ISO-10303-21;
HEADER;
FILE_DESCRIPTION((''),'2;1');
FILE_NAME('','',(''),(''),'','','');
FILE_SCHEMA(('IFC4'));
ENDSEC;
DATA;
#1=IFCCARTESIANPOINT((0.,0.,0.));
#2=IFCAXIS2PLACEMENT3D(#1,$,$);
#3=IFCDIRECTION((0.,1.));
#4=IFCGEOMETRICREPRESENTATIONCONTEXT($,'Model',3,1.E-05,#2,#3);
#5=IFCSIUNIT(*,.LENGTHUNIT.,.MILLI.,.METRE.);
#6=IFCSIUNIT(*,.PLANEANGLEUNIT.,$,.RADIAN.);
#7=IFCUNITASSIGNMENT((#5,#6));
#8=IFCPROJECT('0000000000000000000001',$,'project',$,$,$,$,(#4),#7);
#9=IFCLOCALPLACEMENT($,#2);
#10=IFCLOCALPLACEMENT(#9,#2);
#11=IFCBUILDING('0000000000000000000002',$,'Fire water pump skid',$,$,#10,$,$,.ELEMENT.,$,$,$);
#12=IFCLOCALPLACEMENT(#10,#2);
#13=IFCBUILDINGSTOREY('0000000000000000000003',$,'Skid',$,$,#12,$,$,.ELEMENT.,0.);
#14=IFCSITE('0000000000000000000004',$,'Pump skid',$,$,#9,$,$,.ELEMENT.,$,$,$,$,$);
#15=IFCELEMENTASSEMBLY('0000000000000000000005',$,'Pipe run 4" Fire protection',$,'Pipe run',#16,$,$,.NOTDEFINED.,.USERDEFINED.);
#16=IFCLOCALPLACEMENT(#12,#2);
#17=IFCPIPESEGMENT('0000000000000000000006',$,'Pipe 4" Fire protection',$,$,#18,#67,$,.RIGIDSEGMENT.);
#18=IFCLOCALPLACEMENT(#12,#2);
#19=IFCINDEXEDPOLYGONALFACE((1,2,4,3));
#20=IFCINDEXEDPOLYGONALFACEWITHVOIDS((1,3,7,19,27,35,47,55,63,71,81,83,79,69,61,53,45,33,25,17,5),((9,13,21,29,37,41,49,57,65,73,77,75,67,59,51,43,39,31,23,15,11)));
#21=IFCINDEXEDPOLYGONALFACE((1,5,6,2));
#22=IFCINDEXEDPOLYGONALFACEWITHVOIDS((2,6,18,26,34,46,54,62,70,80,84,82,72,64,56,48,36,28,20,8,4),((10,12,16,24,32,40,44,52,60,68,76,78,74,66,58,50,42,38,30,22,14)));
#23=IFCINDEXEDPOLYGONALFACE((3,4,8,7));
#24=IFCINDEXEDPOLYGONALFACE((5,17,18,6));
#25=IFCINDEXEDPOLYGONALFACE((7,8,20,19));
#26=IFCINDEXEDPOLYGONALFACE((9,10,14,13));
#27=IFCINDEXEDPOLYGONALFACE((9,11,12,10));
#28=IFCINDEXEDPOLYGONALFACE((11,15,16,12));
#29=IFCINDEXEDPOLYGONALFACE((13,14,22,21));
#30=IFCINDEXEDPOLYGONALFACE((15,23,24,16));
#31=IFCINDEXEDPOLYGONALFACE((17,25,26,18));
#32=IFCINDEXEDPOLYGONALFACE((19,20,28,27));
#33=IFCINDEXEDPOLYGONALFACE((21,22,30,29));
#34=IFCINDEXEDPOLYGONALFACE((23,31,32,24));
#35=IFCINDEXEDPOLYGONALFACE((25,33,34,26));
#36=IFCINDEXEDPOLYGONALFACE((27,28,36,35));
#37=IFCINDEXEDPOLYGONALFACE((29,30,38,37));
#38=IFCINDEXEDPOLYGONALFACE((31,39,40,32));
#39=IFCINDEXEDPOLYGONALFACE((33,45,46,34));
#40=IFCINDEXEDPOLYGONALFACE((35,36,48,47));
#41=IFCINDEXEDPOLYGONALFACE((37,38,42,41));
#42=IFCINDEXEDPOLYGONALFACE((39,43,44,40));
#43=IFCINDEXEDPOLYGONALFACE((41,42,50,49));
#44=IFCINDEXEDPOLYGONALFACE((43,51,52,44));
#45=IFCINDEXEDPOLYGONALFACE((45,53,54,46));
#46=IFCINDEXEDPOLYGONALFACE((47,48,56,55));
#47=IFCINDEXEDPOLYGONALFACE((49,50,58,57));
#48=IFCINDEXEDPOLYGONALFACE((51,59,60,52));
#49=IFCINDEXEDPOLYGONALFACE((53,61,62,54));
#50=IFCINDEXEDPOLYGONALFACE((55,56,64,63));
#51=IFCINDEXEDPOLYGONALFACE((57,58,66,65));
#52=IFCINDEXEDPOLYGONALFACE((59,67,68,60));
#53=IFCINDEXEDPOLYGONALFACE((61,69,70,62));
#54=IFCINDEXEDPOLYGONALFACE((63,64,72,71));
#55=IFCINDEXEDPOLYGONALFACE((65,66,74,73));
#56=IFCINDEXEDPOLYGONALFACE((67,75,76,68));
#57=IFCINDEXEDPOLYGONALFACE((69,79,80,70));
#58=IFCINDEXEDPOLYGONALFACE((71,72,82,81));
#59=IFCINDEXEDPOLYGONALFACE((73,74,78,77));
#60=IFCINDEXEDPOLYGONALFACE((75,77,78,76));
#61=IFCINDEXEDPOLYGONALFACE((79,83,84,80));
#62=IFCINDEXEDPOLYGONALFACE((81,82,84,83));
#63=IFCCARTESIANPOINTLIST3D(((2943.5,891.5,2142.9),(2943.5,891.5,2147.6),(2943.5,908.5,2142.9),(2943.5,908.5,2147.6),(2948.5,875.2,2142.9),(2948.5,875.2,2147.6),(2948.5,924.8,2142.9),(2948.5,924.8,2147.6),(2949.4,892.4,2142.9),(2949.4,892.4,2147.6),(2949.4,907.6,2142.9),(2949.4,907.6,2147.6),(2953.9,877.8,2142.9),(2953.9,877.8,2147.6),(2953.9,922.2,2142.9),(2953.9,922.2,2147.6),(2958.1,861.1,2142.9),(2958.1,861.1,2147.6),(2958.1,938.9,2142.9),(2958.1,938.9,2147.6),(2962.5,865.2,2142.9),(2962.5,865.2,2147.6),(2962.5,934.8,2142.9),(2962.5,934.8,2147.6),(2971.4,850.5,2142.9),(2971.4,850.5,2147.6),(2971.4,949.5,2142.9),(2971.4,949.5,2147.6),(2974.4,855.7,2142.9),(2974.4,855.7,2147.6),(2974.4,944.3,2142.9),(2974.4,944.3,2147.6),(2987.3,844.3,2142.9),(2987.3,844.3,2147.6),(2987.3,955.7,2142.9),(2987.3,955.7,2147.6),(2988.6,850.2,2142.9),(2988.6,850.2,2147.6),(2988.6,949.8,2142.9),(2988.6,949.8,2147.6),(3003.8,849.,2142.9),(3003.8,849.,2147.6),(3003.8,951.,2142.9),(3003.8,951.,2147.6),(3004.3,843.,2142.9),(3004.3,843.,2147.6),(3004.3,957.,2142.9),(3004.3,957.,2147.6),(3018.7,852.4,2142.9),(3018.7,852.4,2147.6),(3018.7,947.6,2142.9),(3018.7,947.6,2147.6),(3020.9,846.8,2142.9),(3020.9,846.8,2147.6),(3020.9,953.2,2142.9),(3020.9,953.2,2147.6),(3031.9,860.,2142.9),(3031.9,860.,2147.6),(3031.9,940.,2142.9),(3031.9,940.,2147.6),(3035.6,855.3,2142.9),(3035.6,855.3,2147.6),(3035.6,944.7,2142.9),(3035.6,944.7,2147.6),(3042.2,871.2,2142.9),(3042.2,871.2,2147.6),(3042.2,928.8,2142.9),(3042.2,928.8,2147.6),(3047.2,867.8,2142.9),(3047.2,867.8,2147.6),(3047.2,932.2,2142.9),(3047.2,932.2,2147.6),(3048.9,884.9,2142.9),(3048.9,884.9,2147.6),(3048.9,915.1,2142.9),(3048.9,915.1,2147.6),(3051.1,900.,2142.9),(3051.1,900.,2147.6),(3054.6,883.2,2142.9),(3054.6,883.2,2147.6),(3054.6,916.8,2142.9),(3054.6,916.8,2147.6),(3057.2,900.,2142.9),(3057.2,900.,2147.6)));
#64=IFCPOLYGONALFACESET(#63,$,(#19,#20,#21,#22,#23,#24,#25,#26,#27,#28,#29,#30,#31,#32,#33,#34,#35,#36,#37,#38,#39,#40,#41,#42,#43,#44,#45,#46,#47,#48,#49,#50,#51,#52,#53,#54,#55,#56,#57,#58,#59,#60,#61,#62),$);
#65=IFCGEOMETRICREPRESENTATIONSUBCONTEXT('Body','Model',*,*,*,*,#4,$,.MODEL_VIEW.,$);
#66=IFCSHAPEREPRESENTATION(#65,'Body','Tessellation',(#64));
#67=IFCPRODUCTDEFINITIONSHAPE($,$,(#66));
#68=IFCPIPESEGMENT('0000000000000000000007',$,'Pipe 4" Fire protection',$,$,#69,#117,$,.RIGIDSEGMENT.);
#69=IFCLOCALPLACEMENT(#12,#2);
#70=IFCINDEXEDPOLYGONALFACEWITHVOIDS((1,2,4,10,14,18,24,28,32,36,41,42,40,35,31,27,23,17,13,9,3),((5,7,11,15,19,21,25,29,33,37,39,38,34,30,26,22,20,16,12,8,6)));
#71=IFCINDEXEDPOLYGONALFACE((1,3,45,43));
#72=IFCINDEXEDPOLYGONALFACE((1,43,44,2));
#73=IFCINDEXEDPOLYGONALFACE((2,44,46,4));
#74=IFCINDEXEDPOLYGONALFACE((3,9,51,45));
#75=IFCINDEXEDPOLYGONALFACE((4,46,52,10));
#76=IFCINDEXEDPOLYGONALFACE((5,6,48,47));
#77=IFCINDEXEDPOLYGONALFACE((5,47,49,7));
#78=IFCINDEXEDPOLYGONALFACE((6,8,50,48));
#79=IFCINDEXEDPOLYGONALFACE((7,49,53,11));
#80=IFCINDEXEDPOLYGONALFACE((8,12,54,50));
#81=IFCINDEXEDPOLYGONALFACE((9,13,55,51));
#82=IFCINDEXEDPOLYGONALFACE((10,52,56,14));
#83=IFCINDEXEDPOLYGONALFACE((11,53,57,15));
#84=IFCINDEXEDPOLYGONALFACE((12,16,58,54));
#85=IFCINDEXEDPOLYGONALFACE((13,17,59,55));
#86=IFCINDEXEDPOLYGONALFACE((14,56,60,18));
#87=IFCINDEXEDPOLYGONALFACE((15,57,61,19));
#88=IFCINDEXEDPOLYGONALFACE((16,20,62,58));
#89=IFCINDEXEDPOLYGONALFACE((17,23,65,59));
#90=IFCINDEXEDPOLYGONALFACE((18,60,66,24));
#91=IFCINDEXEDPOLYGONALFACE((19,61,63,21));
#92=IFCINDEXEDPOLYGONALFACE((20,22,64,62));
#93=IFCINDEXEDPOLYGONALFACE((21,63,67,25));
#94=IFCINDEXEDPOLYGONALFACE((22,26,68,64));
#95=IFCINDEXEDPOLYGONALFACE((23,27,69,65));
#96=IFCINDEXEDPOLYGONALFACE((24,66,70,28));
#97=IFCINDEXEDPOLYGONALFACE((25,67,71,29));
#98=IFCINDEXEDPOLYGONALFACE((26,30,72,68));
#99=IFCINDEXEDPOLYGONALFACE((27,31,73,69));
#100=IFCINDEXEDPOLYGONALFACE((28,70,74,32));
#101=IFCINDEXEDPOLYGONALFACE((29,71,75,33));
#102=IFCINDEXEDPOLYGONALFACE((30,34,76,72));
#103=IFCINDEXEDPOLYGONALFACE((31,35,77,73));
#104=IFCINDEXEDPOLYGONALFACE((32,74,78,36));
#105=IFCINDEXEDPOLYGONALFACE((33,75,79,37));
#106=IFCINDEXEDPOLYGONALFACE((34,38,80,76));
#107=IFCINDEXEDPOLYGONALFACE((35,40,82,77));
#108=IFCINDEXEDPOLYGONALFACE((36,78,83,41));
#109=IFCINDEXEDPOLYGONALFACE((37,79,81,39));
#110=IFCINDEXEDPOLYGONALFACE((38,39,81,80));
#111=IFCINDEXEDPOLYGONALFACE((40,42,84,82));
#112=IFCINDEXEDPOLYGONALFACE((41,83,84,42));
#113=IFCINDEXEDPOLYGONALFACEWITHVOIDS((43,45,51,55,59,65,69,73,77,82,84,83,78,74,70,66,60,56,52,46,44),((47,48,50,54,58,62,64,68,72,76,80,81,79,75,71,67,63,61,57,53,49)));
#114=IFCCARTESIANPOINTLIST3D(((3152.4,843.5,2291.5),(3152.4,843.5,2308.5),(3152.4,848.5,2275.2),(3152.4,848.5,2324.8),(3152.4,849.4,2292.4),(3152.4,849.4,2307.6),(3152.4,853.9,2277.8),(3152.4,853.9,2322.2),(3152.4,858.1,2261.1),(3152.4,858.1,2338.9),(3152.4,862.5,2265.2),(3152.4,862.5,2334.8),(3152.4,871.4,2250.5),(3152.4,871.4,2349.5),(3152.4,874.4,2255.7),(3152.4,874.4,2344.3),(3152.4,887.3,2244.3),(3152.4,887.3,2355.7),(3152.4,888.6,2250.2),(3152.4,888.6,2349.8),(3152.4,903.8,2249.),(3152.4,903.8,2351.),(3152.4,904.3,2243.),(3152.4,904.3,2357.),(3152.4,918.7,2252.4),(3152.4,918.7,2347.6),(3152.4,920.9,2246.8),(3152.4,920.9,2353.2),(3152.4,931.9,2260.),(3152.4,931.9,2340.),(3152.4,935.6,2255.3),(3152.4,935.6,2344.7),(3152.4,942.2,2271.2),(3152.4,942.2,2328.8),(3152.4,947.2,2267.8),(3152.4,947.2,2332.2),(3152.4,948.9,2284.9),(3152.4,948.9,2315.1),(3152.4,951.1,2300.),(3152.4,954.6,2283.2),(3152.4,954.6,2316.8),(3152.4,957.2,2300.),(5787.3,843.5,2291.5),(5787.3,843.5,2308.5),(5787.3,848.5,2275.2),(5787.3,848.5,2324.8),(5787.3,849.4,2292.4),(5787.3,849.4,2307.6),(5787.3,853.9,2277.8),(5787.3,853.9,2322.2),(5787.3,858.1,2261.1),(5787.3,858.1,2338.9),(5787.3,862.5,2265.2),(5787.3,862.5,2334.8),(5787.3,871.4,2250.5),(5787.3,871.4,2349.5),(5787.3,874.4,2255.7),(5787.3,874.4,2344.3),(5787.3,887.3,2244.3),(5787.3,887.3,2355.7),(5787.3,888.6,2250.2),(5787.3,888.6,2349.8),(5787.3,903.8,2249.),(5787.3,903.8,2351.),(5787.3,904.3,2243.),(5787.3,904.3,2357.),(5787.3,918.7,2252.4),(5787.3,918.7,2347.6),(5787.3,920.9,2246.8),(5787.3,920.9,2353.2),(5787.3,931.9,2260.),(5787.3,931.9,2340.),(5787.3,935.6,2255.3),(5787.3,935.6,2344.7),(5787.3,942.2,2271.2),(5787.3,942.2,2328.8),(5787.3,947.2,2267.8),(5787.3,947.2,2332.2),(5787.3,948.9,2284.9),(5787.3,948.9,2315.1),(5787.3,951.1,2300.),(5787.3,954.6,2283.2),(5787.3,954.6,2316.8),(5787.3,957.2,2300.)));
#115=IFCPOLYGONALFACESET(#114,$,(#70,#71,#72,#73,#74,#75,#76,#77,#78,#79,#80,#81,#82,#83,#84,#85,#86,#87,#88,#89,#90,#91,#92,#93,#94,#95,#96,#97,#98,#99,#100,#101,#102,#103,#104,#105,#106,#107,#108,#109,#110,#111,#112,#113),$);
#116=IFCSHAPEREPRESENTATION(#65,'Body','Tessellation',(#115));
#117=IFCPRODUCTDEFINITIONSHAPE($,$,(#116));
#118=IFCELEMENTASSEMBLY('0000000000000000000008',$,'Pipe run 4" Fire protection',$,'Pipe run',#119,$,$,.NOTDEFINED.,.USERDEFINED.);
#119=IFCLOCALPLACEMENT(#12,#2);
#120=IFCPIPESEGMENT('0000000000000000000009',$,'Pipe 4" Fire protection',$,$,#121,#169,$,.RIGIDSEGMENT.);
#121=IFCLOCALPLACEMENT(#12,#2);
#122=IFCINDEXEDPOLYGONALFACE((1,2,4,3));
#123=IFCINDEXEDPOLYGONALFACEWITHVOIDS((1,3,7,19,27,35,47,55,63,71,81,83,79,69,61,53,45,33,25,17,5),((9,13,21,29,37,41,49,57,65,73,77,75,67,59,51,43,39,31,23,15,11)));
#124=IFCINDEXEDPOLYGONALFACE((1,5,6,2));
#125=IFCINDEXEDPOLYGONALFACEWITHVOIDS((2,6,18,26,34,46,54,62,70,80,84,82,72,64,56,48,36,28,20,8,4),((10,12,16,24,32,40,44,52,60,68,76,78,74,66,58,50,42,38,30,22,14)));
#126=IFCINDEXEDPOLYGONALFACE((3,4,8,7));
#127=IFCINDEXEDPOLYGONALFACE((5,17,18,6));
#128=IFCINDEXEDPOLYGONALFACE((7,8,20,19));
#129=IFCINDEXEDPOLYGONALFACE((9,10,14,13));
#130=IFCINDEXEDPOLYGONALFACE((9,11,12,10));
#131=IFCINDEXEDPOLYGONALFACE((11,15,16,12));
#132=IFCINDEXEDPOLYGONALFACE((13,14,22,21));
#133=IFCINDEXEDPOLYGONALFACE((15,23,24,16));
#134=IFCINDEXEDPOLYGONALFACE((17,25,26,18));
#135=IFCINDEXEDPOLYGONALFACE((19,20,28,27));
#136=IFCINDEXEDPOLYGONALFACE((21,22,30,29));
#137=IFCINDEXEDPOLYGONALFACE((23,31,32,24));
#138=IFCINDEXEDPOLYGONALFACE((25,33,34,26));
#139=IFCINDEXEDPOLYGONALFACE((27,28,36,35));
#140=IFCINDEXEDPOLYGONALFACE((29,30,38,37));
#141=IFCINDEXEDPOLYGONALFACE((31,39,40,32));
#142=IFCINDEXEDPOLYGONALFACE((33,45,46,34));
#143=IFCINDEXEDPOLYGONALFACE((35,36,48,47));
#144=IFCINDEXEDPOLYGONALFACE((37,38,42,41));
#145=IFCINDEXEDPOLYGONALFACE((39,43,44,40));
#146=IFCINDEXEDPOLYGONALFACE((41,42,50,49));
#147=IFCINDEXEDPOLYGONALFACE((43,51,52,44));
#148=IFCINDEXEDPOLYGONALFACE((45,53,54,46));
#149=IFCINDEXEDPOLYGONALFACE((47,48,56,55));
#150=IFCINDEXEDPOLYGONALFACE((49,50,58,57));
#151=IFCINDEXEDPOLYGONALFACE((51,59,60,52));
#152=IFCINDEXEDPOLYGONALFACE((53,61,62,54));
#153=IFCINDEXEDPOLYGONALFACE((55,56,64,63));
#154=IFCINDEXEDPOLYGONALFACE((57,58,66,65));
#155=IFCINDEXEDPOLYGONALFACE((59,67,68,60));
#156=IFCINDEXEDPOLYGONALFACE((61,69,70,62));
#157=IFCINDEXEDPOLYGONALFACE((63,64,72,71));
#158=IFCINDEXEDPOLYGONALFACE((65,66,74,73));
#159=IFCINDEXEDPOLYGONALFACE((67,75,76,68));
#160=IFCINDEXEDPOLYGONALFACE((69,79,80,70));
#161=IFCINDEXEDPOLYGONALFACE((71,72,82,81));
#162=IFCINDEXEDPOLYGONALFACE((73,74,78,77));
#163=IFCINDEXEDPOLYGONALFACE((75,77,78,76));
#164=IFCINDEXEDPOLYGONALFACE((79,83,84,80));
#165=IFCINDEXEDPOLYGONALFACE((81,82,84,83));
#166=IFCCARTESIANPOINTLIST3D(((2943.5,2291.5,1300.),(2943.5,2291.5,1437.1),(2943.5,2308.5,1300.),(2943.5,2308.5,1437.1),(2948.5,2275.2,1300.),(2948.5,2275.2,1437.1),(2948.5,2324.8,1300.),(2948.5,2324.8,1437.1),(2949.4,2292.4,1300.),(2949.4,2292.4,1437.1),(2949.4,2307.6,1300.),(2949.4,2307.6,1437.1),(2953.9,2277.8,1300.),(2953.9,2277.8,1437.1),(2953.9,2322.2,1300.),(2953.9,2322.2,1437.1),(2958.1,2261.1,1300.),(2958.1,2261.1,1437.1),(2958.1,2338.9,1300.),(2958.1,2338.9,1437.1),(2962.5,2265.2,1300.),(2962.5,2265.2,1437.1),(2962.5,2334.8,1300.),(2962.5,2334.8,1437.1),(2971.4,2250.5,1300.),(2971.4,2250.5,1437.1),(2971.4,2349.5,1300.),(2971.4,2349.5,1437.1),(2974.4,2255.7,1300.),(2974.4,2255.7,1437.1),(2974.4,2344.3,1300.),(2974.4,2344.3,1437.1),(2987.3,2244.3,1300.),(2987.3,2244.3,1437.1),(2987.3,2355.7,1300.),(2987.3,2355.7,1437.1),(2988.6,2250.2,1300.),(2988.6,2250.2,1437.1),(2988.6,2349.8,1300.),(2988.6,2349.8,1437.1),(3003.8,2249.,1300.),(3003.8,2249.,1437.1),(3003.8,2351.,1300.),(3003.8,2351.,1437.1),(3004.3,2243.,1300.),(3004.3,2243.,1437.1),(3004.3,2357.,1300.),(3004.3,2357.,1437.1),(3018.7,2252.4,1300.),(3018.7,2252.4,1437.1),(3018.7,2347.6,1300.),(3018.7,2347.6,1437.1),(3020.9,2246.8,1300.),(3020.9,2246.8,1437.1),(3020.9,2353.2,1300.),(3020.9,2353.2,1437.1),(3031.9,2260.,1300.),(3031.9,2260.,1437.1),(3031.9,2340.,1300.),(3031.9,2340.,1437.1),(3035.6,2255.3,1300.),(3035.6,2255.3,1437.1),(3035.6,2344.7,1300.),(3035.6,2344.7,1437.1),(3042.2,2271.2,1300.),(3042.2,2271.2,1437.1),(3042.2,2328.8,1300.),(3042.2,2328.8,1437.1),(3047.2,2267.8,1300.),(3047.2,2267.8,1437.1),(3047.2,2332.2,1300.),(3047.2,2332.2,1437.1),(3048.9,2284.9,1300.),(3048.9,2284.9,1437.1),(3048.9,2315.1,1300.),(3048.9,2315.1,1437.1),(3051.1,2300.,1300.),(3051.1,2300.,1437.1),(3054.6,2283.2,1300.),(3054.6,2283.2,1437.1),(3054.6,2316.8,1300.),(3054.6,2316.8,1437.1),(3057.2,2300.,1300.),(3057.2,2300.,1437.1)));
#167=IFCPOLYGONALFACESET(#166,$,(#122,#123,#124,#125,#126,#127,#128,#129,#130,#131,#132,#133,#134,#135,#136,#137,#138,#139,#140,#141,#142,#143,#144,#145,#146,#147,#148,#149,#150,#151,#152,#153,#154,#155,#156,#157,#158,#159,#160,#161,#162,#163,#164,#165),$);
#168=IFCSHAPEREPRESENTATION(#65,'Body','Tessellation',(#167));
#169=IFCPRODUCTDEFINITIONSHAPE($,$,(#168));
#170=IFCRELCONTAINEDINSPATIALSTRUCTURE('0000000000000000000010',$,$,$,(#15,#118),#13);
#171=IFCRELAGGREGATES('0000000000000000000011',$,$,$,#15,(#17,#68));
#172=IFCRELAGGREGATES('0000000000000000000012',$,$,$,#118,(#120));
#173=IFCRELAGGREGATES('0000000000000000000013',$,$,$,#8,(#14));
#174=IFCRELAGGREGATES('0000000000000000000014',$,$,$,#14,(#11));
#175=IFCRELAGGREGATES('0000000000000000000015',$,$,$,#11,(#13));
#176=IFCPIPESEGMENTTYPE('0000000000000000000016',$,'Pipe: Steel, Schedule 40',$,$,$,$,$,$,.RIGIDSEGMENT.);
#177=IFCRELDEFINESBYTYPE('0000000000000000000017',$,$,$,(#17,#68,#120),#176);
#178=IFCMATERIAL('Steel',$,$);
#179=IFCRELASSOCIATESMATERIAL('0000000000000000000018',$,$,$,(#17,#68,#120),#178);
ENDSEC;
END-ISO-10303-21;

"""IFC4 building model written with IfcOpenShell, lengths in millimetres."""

from ifc_helpers import new_model, si_unit, direction, frame, origin, origin_with_axes, origin_2d, place, context, subcontext, project, spatial, hollow_circle, extrude, material, type_object, element, aggregate, save


model = new_model("IFC4")

# Units and contexts
model_context = context("Model", 3, precision=1e-05, world=origin(), true_north=direction((0.0, 1.0)))
body_context = subcontext(model_context, "Body", "Model", "MODEL_VIEW")
ifc_project = project(units=[si_unit("LENGTHUNIT", "METRE", prefix="MILLI"), si_unit("PLANEANGLEUNIT", "RADIAN")], contexts=[model_context])

# Site, building, storey
site_placement = place(None, origin())
site = spatial("IfcSite", under=ifc_project, at=site_placement, Name="Pump skid", CompositionType="ELEMENT")
building_placement = place(site_placement, origin())
building = spatial("IfcBuilding", under=site, at=building_placement, Name="Fire water pump skid", CompositionType="ELEMENT")
storey_placement = place(building_placement, origin())
storey = spatial("IfcBuildingStorey", under=building, at=storey_placement, Name="Skid", CompositionType="ELEMENT", Elevation=0.0)

# Element assemblies, pipe segments
ifc_material = material(Name="Steel")
pipe_segment_type = type_object("IfcPipeSegmentType", Name="Pipe: Steel, Schedule 40", PredefinedType="RIGIDSEGMENT")
assembly_1_placement = place(storey_placement, origin_with_axes())
assembly_1 = element("IfcElementAssembly", 1, at=assembly_1_placement, inside=storey, Name="Pipe run 4\" Fire protection", ObjectType="Pipe run", AssemblyPlace="NOTDEFINED", PredefinedType="USERDEFINED")
pipe_segment_1_placement = place(storey_placement, origin_with_axes())
pipe_segment_1 = element("IfcPipeSegment", 2, at=pipe_segment_1_placement, type_object=pipe_segment_type, material=ifc_material, Name="Pipe 4\" Fire protection", PredefinedType="RIGIDSEGMENT", context=body_context, shape_type="SweptSolid", body=[
    extrude(hollow_circle(Radius=57.1, WallThickness=6.0, at=origin_2d()), frame((3000.0, 900.0, 2142.9), z_axis=(0.0, 0.0, 1.0), x_axis=(1.0, 0.0, 0.0)), (0.0, 0.0, 1.0), 4.7),
])
pipe_segment_2_placement = place(storey_placement, origin_with_axes())
pipe_segment_2 = element("IfcPipeSegment", 3, at=pipe_segment_2_placement, type_object=pipe_segment_type, material=ifc_material, Name="Pipe 4\" Fire protection", PredefinedType="RIGIDSEGMENT", context=body_context, shape_type="SweptSolid", body=[
    extrude(hollow_circle(Radius=57.1, WallThickness=6.0, at=origin_2d()), frame((3152.4, 900.0, 2300.0), z_axis=(1.0, 0.0, 0.0), x_axis=(0.0, 1.0, 0.0)), (0.0, 0.0, 1.0), 2634.9),
])
assembly_2_placement = place(storey_placement, origin_with_axes())
assembly_2 = element("IfcElementAssembly", 4, at=assembly_2_placement, inside=storey, Name="Pipe run 4\" Fire protection", ObjectType="Pipe run", AssemblyPlace="NOTDEFINED", PredefinedType="USERDEFINED")
pipe_segment_3_placement = place(storey_placement, origin_with_axes())
pipe_segment_3 = element("IfcPipeSegment", 5, at=pipe_segment_3_placement, type_object=pipe_segment_type, material=ifc_material, Name="Pipe 4\" Fire protection", PredefinedType="RIGIDSEGMENT", context=body_context, shape_type="SweptSolid", body=[
    extrude(hollow_circle(Radius=57.1, WallThickness=6.0, at=origin_2d()), frame((3000.0, 2300.0, 1300.0), z_axis=(0.0, 0.0, 1.0), x_axis=(1.0, 0.0, 0.0)), (0.0, 0.0, 1.0), 137.1),
])

aggregate(assembly_1, [pipe_segment_1, pipe_segment_2])
aggregate(assembly_2, [pipe_segment_3])

save(model, "model.ifc")
